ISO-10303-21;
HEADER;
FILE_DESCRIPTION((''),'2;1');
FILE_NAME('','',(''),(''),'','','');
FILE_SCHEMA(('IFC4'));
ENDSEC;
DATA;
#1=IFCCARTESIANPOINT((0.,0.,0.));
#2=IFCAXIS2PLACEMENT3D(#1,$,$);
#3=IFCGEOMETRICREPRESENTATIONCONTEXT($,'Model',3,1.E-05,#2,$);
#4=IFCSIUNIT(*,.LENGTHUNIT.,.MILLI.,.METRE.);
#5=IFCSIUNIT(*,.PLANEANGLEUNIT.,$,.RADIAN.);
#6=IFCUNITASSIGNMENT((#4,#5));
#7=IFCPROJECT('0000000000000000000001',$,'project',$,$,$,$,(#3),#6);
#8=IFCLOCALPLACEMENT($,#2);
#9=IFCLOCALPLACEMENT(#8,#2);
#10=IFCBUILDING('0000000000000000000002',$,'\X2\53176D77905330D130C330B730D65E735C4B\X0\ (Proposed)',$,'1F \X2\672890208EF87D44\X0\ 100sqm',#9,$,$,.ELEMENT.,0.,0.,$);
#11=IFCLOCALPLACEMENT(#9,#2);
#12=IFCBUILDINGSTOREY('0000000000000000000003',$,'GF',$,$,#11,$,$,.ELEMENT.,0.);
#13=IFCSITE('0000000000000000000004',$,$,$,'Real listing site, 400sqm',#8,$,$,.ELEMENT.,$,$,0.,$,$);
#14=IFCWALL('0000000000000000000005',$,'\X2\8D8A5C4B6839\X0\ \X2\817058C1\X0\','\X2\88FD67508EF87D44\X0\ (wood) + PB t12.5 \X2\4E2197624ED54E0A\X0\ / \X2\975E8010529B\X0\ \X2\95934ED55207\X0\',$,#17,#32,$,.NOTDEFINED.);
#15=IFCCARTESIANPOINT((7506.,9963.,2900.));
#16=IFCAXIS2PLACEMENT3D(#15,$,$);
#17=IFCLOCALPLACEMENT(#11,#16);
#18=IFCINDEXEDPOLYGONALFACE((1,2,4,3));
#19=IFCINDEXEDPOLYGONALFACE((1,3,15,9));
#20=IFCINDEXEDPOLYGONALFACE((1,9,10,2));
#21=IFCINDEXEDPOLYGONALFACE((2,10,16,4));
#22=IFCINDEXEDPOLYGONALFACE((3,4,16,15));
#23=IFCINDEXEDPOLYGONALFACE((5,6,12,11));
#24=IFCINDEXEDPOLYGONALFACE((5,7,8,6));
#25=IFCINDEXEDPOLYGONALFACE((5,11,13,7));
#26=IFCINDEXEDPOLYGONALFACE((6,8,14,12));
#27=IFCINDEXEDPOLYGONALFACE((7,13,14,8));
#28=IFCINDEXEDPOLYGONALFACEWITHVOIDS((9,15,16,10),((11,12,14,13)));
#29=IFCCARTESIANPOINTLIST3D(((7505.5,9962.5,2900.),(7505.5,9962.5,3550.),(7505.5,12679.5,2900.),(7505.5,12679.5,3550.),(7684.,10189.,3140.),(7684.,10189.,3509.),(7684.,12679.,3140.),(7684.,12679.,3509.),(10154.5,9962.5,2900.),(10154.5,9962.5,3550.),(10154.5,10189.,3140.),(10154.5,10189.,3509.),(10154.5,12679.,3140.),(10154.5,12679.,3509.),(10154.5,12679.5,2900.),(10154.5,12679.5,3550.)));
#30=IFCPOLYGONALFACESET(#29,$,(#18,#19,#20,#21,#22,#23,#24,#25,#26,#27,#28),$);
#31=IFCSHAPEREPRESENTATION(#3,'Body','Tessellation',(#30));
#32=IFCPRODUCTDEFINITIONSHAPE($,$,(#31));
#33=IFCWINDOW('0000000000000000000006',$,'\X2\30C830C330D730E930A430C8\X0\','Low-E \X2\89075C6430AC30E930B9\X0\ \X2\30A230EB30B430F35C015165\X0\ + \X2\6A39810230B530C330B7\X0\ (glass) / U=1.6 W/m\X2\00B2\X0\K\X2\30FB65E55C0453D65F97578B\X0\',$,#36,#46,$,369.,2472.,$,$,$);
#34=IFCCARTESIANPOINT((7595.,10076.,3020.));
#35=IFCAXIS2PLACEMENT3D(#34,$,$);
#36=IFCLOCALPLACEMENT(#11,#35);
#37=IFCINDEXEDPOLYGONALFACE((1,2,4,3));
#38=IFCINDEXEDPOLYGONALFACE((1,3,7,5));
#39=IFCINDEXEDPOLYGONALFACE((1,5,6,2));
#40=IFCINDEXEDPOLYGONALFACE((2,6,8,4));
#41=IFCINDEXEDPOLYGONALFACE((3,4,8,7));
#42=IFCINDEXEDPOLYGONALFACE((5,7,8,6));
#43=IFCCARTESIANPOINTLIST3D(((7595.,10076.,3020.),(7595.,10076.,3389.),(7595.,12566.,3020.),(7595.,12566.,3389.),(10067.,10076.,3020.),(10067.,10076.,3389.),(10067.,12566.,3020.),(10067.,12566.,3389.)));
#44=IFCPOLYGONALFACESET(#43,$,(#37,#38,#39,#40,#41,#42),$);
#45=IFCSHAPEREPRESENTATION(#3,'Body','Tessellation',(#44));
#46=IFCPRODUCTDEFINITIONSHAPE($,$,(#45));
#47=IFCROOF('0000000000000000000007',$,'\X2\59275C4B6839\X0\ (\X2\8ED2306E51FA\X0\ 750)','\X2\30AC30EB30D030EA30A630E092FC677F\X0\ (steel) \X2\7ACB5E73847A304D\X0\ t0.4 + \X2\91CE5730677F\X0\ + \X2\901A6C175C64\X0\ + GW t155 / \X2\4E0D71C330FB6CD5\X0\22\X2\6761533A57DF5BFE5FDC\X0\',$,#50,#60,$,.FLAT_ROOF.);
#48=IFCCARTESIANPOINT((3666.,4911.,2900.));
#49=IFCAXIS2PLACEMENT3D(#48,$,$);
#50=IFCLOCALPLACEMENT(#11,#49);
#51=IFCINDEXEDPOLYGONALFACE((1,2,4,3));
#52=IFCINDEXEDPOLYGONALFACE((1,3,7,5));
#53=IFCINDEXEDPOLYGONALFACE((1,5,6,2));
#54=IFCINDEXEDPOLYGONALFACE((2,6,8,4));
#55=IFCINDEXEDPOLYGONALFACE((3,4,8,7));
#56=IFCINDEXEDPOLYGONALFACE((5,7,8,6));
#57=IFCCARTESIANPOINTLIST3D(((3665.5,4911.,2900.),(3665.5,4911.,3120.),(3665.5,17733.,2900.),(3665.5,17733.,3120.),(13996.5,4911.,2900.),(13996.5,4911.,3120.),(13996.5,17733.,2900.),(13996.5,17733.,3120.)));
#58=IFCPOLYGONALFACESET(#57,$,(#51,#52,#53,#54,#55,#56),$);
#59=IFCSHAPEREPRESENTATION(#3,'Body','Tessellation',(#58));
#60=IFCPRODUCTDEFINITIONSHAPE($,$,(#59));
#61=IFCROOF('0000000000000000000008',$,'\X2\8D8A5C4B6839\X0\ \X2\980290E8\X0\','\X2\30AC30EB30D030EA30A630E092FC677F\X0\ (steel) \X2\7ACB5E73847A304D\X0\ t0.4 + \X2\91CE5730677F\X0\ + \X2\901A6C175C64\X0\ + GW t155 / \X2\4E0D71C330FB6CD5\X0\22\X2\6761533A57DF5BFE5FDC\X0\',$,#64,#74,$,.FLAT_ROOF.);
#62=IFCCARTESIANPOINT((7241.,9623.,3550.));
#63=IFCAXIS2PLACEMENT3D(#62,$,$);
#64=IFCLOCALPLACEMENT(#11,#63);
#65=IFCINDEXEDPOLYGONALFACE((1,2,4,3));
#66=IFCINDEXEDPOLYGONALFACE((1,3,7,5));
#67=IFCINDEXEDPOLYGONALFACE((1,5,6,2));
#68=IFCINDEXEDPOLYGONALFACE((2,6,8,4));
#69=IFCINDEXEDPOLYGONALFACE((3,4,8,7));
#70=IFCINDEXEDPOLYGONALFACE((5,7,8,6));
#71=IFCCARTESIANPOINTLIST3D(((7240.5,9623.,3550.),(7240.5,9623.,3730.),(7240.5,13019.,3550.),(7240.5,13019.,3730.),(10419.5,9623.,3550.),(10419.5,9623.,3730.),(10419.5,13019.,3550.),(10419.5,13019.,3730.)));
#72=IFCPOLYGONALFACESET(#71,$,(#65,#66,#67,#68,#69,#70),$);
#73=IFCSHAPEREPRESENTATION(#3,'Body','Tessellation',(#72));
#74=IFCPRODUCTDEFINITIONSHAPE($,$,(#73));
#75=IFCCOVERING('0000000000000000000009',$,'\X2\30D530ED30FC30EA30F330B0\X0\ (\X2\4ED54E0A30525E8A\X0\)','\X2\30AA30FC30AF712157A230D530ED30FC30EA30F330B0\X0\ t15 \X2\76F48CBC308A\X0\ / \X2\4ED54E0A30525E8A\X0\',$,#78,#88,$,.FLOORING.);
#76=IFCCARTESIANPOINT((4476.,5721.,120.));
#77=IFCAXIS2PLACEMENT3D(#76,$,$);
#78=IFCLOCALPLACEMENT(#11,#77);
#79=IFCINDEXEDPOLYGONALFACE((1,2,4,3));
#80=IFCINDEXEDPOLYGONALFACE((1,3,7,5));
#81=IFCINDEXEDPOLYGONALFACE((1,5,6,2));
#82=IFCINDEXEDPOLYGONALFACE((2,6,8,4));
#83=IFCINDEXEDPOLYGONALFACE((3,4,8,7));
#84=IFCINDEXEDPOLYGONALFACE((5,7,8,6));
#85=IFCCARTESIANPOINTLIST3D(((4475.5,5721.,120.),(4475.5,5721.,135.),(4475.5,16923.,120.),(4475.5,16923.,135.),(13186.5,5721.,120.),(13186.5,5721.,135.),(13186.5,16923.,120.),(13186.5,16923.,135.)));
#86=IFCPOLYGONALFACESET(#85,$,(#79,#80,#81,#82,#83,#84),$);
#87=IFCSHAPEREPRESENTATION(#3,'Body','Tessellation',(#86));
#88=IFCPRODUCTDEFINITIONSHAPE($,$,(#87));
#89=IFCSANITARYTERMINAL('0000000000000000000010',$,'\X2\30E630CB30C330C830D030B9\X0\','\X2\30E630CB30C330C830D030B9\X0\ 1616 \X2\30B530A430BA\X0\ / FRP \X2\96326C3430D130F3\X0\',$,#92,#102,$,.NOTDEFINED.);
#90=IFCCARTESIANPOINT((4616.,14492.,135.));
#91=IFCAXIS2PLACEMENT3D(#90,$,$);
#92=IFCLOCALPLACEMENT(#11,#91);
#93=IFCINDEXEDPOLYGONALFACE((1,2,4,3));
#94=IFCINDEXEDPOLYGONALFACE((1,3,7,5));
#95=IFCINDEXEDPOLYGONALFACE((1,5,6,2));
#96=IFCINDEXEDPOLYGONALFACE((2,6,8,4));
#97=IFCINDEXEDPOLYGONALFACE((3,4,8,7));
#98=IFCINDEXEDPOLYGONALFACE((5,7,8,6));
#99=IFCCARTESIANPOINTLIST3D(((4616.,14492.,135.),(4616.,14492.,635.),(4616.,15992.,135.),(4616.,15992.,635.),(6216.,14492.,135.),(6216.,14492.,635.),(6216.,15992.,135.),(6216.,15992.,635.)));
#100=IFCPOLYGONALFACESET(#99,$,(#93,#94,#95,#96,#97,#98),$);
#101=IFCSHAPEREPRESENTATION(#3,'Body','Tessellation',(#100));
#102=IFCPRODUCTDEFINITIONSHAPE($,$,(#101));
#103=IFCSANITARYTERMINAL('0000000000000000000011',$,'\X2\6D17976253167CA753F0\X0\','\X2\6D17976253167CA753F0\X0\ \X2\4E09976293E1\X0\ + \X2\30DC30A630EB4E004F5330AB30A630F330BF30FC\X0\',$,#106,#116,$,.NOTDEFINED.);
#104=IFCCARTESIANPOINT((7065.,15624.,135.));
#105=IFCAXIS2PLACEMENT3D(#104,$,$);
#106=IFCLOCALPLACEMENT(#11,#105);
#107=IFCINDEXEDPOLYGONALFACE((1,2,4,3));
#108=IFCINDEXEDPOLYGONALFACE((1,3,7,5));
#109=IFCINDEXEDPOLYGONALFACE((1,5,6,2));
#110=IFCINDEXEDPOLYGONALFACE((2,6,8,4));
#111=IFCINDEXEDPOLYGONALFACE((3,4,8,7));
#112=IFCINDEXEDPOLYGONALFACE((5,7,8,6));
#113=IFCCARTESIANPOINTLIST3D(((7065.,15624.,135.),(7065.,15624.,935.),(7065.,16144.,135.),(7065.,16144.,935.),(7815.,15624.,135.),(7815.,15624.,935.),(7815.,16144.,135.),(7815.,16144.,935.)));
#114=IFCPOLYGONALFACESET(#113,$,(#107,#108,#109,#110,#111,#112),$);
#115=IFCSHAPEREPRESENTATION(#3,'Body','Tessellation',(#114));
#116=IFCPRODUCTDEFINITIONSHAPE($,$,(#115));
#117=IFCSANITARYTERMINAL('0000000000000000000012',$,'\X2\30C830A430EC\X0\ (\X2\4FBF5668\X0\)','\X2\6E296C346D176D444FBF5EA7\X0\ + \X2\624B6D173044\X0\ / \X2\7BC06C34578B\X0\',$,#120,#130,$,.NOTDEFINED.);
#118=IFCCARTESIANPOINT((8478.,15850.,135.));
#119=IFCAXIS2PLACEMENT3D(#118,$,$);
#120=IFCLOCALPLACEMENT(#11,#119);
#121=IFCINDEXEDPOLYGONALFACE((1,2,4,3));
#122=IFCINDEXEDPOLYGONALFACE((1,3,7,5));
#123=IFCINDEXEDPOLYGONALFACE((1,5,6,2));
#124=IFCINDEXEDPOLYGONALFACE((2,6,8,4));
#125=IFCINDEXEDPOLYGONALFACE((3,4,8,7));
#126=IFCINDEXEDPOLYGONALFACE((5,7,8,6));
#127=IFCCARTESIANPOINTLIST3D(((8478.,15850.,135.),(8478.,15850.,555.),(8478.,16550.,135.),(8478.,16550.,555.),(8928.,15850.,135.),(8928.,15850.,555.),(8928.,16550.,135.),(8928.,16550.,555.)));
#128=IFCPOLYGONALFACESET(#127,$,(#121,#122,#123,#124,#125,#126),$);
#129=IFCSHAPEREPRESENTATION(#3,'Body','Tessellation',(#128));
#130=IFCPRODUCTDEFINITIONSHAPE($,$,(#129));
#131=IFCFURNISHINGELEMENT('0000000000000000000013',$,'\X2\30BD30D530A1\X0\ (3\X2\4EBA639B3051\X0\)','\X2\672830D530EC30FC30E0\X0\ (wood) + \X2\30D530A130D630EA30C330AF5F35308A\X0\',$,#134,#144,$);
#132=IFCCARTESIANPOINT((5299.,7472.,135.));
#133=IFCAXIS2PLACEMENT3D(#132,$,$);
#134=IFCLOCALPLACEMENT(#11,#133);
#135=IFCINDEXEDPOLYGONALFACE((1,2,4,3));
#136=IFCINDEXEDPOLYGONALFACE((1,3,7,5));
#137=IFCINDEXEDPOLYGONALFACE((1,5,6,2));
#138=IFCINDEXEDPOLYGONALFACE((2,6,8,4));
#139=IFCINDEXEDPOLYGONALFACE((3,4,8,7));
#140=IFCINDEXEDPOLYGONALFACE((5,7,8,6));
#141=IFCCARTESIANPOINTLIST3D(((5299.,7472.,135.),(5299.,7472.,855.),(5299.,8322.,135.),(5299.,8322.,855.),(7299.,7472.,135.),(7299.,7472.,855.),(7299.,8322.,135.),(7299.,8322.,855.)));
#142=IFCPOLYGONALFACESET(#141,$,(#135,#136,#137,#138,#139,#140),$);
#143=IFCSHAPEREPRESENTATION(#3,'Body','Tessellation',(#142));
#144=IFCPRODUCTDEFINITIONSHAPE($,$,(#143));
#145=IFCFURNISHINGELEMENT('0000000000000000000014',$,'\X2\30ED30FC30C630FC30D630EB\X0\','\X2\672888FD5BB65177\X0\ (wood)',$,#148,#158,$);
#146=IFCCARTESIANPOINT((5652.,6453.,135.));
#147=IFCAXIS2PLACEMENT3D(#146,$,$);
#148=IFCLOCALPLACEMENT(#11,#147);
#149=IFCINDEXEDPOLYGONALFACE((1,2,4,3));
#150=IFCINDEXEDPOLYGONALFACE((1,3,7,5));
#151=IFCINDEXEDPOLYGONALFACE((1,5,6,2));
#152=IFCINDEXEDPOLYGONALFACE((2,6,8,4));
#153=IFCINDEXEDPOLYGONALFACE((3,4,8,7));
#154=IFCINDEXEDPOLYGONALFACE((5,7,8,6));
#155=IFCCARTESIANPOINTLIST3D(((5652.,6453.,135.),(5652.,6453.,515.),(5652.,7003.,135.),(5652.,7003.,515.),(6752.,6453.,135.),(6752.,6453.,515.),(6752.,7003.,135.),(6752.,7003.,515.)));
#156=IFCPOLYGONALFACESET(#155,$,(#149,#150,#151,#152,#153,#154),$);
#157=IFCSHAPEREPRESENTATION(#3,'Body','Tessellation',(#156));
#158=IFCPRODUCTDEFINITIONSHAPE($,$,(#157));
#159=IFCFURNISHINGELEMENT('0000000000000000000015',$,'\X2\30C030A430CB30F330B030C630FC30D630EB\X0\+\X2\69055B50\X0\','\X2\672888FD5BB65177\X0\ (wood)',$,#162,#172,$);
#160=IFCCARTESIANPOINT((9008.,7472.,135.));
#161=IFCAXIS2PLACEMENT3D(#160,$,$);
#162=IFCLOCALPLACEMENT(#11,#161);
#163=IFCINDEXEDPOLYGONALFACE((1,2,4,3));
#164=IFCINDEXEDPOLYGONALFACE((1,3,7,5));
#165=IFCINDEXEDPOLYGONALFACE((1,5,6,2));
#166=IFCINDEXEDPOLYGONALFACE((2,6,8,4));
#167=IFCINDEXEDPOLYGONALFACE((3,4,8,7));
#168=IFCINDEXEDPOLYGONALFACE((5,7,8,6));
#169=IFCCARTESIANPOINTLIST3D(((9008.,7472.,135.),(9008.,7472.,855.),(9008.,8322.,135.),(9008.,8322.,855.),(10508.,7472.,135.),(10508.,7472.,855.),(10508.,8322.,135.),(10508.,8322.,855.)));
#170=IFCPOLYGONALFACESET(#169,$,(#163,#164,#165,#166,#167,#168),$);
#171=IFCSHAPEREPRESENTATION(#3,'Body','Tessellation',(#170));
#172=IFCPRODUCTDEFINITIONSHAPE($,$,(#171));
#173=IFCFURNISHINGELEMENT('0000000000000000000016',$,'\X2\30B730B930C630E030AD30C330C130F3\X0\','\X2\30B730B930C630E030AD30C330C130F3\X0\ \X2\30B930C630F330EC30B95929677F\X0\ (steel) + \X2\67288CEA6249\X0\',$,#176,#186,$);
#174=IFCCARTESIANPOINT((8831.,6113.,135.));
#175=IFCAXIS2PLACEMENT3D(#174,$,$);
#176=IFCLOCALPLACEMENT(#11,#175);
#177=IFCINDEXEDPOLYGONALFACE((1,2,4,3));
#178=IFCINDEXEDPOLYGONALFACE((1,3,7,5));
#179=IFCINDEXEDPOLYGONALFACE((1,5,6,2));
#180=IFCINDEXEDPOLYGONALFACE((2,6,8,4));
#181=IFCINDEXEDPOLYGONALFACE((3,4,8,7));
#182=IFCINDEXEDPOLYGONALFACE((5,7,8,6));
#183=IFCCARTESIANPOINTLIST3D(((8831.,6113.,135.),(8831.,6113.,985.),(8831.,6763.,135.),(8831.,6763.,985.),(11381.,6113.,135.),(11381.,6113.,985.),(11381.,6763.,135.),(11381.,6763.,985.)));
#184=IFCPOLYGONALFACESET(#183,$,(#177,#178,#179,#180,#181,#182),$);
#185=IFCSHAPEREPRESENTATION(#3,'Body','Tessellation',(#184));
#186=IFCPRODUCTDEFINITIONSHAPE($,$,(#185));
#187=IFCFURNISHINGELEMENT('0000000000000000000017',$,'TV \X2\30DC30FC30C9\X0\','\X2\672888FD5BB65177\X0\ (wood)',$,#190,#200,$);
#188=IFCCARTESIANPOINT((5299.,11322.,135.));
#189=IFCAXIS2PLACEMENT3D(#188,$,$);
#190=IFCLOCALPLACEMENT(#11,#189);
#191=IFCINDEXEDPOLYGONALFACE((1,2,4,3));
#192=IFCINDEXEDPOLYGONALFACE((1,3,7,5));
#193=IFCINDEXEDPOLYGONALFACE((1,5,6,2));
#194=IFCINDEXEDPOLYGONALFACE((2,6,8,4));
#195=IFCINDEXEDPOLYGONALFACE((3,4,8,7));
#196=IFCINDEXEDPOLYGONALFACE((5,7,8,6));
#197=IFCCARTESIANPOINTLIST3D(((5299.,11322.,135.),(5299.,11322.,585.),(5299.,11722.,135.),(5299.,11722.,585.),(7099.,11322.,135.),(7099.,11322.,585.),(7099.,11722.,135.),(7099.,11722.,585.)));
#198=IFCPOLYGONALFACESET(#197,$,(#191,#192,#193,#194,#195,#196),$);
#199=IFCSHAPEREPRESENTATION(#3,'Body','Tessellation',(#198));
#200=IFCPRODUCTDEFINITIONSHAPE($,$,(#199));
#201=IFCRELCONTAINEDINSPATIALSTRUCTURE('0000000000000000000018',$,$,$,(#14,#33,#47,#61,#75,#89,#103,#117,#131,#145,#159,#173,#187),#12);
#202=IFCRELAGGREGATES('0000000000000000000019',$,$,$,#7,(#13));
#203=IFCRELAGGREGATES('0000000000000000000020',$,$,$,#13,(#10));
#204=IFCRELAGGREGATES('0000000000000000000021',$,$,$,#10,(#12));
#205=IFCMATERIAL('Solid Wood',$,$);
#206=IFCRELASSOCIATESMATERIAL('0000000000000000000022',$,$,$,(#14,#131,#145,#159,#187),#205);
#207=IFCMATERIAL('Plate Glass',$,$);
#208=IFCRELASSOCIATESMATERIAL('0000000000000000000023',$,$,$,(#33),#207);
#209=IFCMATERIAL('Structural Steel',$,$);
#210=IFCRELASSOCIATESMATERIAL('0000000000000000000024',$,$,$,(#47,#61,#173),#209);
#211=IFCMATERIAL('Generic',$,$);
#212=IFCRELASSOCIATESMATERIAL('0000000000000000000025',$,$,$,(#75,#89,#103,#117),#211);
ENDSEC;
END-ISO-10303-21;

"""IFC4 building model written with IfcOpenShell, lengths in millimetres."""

from ifc_helpers import new_model, si_unit, frame, frame_2d, origin, place, context, project, spatial, rectangle, extrude, material, element, fill, save


model = new_model("IFC4")

# Units and contexts
model_context = context("Model", 3, precision=1e-05, world=origin())
ifc_project = project(units=[si_unit("LENGTHUNIT", "METRE", prefix="MILLI"), si_unit("PLANEANGLEUNIT", "RADIAN")], contexts=[model_context])

# Site, building, storey
site_placement = place(None, origin())
site = spatial("IfcSite", under=ifc_project, at=site_placement, ObjectType="Real listing site, 400sqm", CompositionType="ELEMENT", RefElevation=0.0)
building_placement = place(site_placement, origin())
building = spatial("IfcBuilding", under=site, at=building_placement, Name="北海道パッシブ平屋 (Proposed)", ObjectType="1F 木造軸組 100sqm", CompositionType="ELEMENT", ElevationOfRefHeight=0.0, ElevationOfTerrain=0.0)
storey_placement = place(building_placement, origin())
storey = spatial("IfcBuildingStorey", under=building, at=storey_placement, Name="GF", CompositionType="ELEMENT", Elevation=0.0)

# Shared definitions
ifc_material_1 = material(Name="Solid Wood")

# Shared definitions
ifc_material_2 = material(Name="Plate Glass")

# Wall, opening, window
wall_1_placement = place(storey_placement, frame((7506.0, 9963.0, 2900.0)))
wall_1 = element("IfcWall", 1, at=wall_1_placement, inside=storey, material=ifc_material_1, Name="越屋根 腰壁", Description="製材軸組 (wood) + PB t12.5 両面仕上 / 非耐力 間仕切", PredefinedType="NOTDEFINED", context=model_context, shape_type="SweptSolid", body=[
    extrude(rectangle(XDim=2649.0, YDim=2717.0, at=frame_2d((1324.0, 1358.0))), frame((7506.0, 9963.0, 2900.0)), (0.0, 0.0, 1.0), 650.0),
])
opening_1_placement = place(storey_placement, frame((7595.0, 10076.0, 3020.0)))
opening_1 = element("IfcOpeningElement", 2, at=opening_1_placement, cuts=wall_1, PredefinedType="NOTDEFINED", context=model_context, shape_type="SweptSolid", body=[
    extrude(rectangle(XDim=2472.0, YDim=2490.0, at=frame_2d((1236.0, 1245.0))), frame((7595.0, 10076.0, 3020.0)), (0.0, 0.0, 1.0), 369.0),
])
window_1_placement = place(storey_placement, frame((7595.0, 10076.0, 3020.0)))
window_1 = element("IfcWindow", 3, at=window_1_placement, inside=storey, material=ifc_material_2, Name="トップライト", Description="Low-E 複層ガラス アルゴン封入 + 樹脂サッシ (glass) / U=1.6 W/m²K・日射取得型", OverallHeight=369.0, OverallWidth=2472.0, context=model_context, shape_type="SweptSolid", body=[
    extrude(rectangle(XDim=2472.0, YDim=2490.0, at=frame_2d((1236.0, 1245.0))), frame((7595.0, 10076.0, 3020.0)), (0.0, 0.0, 1.0), 369.0),
])
fill(opening_1, window_1)

# Roofs
ifc_material_3 = material(Name="Structural Steel")
roof_1_placement = place(storey_placement, frame((3666.0, 4911.0, 2900.0)))
element("IfcRoof", 4, at=roof_1_placement, inside=storey, material=ifc_material_3, Name="大屋根 (軒の出 750)", Description="ガルバリウム鋼板 (steel) 立平葺き t0.4 + 野地板 + 通気層 + GW t155 / 不燃・法22条区域対応", PredefinedType="FLAT_ROOF", context=model_context, shape_type="SweptSolid", body=[
    extrude(rectangle(XDim=10331.0, YDim=12822.0, at=frame_2d((5165.0, 6411.0))), frame((3666.0, 4911.0, 2900.0)), (0.0, 0.0, 1.0), 220.0),
])
roof_2_placement = place(storey_placement, frame((7241.0, 9623.0, 3550.0)))
element("IfcRoof", 5, at=roof_2_placement, inside=storey, material=ifc_material_3, Name="越屋根 頂部", Description="ガルバリウム鋼板 (steel) 立平葺き t0.4 + 野地板 + 通気層 + GW t155 / 不燃・法22条区域対応", PredefinedType="FLAT_ROOF", context=model_context, shape_type="SweptSolid", body=[
    extrude(rectangle(XDim=3179.0, YDim=3396.0, at=frame_2d((1589.0, 1698.0))), frame((7241.0, 9623.0, 3550.0)), (0.0, 0.0, 1.0), 180.0),
])

# Covering
ifc_material_4 = material(Name="Generic")
covering_placement = place(storey_placement, frame((4476.0, 5721.0, 120.0)))
element("IfcCovering", 6, at=covering_placement, inside=storey, material=ifc_material_4, Name="フローリング (仕上げ床)", Description="オーク無垢フローリング t15 直貼り / 仕上げ床", PredefinedType="FLOORING", context=model_context, shape_type="SweptSolid", body=[
    extrude(rectangle(XDim=8711.0, YDim=11202.0, at=frame_2d((4355.0, 5601.0))), frame((4476.0, 5721.0, 120.0)), (0.0, 0.0, 1.0), 15.0),
])

# Sanitary terminals
sanitary_terminal_1_placement = place(storey_placement, frame((4616.0, 14492.0, 135.0)))
element("IfcSanitaryTerminal", 7, at=sanitary_terminal_1_placement, inside=storey, material=ifc_material_4, Name="ユニットバス", Description="ユニットバス 1616 サイズ / FRP 防水パン", PredefinedType="NOTDEFINED", context=model_context, shape_type="SweptSolid", body=[
    extrude(rectangle(XDim=1600.0, YDim=1500.0, at=frame_2d((800.0, 750.0))), frame((4616.0, 14492.0, 135.0)), (0.0, 0.0, 1.0), 500.0),
])
sanitary_terminal_2_placement = place(storey_placement, frame((7065.0, 15624.0, 135.0)))
element("IfcSanitaryTerminal", 8, at=sanitary_terminal_2_placement, inside=storey, material=ifc_material_4, Name="洗面化粧台", Description="洗面化粧台 三面鏡 + ボウル一体カウンター", PredefinedType="NOTDEFINED", context=model_context, shape_type="SweptSolid", body=[
    extrude(rectangle(XDim=750.0, YDim=520.0, at=frame_2d((375.0, 260.0))), frame((7065.0, 15624.0, 135.0)), (0.0, 0.0, 1.0), 800.0),
])
sanitary_terminal_3_placement = place(storey_placement, frame((8478.0, 15850.0, 135.0)))
element("IfcSanitaryTerminal", 9, at=sanitary_terminal_3_placement, inside=storey, material=ifc_material_4, Name="トイレ (便器)", Description="温水洗浄便座 + 手洗い / 節水型", PredefinedType="NOTDEFINED", context=model_context, shape_type="SweptSolid", body=[
    extrude(rectangle(XDim=450.0, YDim=700.0, at=frame_2d((225.0, 350.0))), frame((8478.0, 15850.0, 135.0)), (0.0, 0.0, 1.0), 420.0),
])

# Furnishing elements
furnishing_1_placement = place(storey_placement, frame((5299.0, 7472.0, 135.0)))
element("IfcFurnishingElement", 10, at=furnishing_1_placement, inside=storey, material=ifc_material_1, Name="ソファ (3人掛け)", Description="木フレーム (wood) + ファブリック張り", context=model_context, shape_type="SweptSolid", body=[
    extrude(rectangle(XDim=2000.0, YDim=850.0, at=frame_2d((1000.0, 425.0))), frame((5299.0, 7472.0, 135.0)), (0.0, 0.0, 1.0), 720.0),
])
furnishing_2_placement = place(storey_placement, frame((5652.0, 6453.0, 135.0)))
element("IfcFurnishingElement", 11, at=furnishing_2_placement, inside=storey, material=ifc_material_1, Name="ローテーブル", Description="木製家具 (wood)", context=model_context, shape_type="SweptSolid", body=[
    extrude(rectangle(XDim=1100.0, YDim=550.0, at=frame_2d((550.0, 275.0))), frame((5652.0, 6453.0, 135.0)), (0.0, 0.0, 1.0), 380.0),
])
furnishing_3_placement = place(storey_placement, frame((9008.0, 7472.0, 135.0)))
element("IfcFurnishingElement", 12, at=furnishing_3_placement, inside=storey, material=ifc_material_1, Name="ダイニングテーブル+椅子", Description="木製家具 (wood)", context=model_context, shape_type="SweptSolid", body=[
    extrude(rectangle(XDim=1500.0, YDim=850.0, at=frame_2d((750.0, 425.0))), frame((9008.0, 7472.0, 135.0)), (0.0, 0.0, 1.0), 720.0),
])
furnishing_4_placement = place(storey_placement, frame((8831.0, 6113.0, 135.0)))
element("IfcFurnishingElement", 13, at=furnishing_4_placement, inside=storey, material=ifc_material_3, Name="システムキッチン", Description="システムキッチン ステンレス天板 (steel) + 木質扉", context=model_context, shape_type="SweptSolid", body=[
    extrude(rectangle(XDim=2550.0, YDim=650.0, at=frame_2d((1275.0, 325.0))), frame((8831.0, 6113.0, 135.0)), (0.0, 0.0, 1.0), 850.0),
])
furnishing_5_placement = place(storey_placement, frame((5299.0, 11322.0, 135.0)))
element("IfcFurnishingElement", 14, at=furnishing_5_placement, inside=storey, material=ifc_material_1, Name="TV ボード", Description="木製家具 (wood)", context=model_context, shape_type="SweptSolid", body=[
    extrude(rectangle(XDim=1800.0, YDim=400.0, at=frame_2d((900.0, 200.0))), frame((5299.0, 11322.0, 135.0)), (0.0, 0.0, 1.0), 450.0),
])

save(model, "model.ifc")
